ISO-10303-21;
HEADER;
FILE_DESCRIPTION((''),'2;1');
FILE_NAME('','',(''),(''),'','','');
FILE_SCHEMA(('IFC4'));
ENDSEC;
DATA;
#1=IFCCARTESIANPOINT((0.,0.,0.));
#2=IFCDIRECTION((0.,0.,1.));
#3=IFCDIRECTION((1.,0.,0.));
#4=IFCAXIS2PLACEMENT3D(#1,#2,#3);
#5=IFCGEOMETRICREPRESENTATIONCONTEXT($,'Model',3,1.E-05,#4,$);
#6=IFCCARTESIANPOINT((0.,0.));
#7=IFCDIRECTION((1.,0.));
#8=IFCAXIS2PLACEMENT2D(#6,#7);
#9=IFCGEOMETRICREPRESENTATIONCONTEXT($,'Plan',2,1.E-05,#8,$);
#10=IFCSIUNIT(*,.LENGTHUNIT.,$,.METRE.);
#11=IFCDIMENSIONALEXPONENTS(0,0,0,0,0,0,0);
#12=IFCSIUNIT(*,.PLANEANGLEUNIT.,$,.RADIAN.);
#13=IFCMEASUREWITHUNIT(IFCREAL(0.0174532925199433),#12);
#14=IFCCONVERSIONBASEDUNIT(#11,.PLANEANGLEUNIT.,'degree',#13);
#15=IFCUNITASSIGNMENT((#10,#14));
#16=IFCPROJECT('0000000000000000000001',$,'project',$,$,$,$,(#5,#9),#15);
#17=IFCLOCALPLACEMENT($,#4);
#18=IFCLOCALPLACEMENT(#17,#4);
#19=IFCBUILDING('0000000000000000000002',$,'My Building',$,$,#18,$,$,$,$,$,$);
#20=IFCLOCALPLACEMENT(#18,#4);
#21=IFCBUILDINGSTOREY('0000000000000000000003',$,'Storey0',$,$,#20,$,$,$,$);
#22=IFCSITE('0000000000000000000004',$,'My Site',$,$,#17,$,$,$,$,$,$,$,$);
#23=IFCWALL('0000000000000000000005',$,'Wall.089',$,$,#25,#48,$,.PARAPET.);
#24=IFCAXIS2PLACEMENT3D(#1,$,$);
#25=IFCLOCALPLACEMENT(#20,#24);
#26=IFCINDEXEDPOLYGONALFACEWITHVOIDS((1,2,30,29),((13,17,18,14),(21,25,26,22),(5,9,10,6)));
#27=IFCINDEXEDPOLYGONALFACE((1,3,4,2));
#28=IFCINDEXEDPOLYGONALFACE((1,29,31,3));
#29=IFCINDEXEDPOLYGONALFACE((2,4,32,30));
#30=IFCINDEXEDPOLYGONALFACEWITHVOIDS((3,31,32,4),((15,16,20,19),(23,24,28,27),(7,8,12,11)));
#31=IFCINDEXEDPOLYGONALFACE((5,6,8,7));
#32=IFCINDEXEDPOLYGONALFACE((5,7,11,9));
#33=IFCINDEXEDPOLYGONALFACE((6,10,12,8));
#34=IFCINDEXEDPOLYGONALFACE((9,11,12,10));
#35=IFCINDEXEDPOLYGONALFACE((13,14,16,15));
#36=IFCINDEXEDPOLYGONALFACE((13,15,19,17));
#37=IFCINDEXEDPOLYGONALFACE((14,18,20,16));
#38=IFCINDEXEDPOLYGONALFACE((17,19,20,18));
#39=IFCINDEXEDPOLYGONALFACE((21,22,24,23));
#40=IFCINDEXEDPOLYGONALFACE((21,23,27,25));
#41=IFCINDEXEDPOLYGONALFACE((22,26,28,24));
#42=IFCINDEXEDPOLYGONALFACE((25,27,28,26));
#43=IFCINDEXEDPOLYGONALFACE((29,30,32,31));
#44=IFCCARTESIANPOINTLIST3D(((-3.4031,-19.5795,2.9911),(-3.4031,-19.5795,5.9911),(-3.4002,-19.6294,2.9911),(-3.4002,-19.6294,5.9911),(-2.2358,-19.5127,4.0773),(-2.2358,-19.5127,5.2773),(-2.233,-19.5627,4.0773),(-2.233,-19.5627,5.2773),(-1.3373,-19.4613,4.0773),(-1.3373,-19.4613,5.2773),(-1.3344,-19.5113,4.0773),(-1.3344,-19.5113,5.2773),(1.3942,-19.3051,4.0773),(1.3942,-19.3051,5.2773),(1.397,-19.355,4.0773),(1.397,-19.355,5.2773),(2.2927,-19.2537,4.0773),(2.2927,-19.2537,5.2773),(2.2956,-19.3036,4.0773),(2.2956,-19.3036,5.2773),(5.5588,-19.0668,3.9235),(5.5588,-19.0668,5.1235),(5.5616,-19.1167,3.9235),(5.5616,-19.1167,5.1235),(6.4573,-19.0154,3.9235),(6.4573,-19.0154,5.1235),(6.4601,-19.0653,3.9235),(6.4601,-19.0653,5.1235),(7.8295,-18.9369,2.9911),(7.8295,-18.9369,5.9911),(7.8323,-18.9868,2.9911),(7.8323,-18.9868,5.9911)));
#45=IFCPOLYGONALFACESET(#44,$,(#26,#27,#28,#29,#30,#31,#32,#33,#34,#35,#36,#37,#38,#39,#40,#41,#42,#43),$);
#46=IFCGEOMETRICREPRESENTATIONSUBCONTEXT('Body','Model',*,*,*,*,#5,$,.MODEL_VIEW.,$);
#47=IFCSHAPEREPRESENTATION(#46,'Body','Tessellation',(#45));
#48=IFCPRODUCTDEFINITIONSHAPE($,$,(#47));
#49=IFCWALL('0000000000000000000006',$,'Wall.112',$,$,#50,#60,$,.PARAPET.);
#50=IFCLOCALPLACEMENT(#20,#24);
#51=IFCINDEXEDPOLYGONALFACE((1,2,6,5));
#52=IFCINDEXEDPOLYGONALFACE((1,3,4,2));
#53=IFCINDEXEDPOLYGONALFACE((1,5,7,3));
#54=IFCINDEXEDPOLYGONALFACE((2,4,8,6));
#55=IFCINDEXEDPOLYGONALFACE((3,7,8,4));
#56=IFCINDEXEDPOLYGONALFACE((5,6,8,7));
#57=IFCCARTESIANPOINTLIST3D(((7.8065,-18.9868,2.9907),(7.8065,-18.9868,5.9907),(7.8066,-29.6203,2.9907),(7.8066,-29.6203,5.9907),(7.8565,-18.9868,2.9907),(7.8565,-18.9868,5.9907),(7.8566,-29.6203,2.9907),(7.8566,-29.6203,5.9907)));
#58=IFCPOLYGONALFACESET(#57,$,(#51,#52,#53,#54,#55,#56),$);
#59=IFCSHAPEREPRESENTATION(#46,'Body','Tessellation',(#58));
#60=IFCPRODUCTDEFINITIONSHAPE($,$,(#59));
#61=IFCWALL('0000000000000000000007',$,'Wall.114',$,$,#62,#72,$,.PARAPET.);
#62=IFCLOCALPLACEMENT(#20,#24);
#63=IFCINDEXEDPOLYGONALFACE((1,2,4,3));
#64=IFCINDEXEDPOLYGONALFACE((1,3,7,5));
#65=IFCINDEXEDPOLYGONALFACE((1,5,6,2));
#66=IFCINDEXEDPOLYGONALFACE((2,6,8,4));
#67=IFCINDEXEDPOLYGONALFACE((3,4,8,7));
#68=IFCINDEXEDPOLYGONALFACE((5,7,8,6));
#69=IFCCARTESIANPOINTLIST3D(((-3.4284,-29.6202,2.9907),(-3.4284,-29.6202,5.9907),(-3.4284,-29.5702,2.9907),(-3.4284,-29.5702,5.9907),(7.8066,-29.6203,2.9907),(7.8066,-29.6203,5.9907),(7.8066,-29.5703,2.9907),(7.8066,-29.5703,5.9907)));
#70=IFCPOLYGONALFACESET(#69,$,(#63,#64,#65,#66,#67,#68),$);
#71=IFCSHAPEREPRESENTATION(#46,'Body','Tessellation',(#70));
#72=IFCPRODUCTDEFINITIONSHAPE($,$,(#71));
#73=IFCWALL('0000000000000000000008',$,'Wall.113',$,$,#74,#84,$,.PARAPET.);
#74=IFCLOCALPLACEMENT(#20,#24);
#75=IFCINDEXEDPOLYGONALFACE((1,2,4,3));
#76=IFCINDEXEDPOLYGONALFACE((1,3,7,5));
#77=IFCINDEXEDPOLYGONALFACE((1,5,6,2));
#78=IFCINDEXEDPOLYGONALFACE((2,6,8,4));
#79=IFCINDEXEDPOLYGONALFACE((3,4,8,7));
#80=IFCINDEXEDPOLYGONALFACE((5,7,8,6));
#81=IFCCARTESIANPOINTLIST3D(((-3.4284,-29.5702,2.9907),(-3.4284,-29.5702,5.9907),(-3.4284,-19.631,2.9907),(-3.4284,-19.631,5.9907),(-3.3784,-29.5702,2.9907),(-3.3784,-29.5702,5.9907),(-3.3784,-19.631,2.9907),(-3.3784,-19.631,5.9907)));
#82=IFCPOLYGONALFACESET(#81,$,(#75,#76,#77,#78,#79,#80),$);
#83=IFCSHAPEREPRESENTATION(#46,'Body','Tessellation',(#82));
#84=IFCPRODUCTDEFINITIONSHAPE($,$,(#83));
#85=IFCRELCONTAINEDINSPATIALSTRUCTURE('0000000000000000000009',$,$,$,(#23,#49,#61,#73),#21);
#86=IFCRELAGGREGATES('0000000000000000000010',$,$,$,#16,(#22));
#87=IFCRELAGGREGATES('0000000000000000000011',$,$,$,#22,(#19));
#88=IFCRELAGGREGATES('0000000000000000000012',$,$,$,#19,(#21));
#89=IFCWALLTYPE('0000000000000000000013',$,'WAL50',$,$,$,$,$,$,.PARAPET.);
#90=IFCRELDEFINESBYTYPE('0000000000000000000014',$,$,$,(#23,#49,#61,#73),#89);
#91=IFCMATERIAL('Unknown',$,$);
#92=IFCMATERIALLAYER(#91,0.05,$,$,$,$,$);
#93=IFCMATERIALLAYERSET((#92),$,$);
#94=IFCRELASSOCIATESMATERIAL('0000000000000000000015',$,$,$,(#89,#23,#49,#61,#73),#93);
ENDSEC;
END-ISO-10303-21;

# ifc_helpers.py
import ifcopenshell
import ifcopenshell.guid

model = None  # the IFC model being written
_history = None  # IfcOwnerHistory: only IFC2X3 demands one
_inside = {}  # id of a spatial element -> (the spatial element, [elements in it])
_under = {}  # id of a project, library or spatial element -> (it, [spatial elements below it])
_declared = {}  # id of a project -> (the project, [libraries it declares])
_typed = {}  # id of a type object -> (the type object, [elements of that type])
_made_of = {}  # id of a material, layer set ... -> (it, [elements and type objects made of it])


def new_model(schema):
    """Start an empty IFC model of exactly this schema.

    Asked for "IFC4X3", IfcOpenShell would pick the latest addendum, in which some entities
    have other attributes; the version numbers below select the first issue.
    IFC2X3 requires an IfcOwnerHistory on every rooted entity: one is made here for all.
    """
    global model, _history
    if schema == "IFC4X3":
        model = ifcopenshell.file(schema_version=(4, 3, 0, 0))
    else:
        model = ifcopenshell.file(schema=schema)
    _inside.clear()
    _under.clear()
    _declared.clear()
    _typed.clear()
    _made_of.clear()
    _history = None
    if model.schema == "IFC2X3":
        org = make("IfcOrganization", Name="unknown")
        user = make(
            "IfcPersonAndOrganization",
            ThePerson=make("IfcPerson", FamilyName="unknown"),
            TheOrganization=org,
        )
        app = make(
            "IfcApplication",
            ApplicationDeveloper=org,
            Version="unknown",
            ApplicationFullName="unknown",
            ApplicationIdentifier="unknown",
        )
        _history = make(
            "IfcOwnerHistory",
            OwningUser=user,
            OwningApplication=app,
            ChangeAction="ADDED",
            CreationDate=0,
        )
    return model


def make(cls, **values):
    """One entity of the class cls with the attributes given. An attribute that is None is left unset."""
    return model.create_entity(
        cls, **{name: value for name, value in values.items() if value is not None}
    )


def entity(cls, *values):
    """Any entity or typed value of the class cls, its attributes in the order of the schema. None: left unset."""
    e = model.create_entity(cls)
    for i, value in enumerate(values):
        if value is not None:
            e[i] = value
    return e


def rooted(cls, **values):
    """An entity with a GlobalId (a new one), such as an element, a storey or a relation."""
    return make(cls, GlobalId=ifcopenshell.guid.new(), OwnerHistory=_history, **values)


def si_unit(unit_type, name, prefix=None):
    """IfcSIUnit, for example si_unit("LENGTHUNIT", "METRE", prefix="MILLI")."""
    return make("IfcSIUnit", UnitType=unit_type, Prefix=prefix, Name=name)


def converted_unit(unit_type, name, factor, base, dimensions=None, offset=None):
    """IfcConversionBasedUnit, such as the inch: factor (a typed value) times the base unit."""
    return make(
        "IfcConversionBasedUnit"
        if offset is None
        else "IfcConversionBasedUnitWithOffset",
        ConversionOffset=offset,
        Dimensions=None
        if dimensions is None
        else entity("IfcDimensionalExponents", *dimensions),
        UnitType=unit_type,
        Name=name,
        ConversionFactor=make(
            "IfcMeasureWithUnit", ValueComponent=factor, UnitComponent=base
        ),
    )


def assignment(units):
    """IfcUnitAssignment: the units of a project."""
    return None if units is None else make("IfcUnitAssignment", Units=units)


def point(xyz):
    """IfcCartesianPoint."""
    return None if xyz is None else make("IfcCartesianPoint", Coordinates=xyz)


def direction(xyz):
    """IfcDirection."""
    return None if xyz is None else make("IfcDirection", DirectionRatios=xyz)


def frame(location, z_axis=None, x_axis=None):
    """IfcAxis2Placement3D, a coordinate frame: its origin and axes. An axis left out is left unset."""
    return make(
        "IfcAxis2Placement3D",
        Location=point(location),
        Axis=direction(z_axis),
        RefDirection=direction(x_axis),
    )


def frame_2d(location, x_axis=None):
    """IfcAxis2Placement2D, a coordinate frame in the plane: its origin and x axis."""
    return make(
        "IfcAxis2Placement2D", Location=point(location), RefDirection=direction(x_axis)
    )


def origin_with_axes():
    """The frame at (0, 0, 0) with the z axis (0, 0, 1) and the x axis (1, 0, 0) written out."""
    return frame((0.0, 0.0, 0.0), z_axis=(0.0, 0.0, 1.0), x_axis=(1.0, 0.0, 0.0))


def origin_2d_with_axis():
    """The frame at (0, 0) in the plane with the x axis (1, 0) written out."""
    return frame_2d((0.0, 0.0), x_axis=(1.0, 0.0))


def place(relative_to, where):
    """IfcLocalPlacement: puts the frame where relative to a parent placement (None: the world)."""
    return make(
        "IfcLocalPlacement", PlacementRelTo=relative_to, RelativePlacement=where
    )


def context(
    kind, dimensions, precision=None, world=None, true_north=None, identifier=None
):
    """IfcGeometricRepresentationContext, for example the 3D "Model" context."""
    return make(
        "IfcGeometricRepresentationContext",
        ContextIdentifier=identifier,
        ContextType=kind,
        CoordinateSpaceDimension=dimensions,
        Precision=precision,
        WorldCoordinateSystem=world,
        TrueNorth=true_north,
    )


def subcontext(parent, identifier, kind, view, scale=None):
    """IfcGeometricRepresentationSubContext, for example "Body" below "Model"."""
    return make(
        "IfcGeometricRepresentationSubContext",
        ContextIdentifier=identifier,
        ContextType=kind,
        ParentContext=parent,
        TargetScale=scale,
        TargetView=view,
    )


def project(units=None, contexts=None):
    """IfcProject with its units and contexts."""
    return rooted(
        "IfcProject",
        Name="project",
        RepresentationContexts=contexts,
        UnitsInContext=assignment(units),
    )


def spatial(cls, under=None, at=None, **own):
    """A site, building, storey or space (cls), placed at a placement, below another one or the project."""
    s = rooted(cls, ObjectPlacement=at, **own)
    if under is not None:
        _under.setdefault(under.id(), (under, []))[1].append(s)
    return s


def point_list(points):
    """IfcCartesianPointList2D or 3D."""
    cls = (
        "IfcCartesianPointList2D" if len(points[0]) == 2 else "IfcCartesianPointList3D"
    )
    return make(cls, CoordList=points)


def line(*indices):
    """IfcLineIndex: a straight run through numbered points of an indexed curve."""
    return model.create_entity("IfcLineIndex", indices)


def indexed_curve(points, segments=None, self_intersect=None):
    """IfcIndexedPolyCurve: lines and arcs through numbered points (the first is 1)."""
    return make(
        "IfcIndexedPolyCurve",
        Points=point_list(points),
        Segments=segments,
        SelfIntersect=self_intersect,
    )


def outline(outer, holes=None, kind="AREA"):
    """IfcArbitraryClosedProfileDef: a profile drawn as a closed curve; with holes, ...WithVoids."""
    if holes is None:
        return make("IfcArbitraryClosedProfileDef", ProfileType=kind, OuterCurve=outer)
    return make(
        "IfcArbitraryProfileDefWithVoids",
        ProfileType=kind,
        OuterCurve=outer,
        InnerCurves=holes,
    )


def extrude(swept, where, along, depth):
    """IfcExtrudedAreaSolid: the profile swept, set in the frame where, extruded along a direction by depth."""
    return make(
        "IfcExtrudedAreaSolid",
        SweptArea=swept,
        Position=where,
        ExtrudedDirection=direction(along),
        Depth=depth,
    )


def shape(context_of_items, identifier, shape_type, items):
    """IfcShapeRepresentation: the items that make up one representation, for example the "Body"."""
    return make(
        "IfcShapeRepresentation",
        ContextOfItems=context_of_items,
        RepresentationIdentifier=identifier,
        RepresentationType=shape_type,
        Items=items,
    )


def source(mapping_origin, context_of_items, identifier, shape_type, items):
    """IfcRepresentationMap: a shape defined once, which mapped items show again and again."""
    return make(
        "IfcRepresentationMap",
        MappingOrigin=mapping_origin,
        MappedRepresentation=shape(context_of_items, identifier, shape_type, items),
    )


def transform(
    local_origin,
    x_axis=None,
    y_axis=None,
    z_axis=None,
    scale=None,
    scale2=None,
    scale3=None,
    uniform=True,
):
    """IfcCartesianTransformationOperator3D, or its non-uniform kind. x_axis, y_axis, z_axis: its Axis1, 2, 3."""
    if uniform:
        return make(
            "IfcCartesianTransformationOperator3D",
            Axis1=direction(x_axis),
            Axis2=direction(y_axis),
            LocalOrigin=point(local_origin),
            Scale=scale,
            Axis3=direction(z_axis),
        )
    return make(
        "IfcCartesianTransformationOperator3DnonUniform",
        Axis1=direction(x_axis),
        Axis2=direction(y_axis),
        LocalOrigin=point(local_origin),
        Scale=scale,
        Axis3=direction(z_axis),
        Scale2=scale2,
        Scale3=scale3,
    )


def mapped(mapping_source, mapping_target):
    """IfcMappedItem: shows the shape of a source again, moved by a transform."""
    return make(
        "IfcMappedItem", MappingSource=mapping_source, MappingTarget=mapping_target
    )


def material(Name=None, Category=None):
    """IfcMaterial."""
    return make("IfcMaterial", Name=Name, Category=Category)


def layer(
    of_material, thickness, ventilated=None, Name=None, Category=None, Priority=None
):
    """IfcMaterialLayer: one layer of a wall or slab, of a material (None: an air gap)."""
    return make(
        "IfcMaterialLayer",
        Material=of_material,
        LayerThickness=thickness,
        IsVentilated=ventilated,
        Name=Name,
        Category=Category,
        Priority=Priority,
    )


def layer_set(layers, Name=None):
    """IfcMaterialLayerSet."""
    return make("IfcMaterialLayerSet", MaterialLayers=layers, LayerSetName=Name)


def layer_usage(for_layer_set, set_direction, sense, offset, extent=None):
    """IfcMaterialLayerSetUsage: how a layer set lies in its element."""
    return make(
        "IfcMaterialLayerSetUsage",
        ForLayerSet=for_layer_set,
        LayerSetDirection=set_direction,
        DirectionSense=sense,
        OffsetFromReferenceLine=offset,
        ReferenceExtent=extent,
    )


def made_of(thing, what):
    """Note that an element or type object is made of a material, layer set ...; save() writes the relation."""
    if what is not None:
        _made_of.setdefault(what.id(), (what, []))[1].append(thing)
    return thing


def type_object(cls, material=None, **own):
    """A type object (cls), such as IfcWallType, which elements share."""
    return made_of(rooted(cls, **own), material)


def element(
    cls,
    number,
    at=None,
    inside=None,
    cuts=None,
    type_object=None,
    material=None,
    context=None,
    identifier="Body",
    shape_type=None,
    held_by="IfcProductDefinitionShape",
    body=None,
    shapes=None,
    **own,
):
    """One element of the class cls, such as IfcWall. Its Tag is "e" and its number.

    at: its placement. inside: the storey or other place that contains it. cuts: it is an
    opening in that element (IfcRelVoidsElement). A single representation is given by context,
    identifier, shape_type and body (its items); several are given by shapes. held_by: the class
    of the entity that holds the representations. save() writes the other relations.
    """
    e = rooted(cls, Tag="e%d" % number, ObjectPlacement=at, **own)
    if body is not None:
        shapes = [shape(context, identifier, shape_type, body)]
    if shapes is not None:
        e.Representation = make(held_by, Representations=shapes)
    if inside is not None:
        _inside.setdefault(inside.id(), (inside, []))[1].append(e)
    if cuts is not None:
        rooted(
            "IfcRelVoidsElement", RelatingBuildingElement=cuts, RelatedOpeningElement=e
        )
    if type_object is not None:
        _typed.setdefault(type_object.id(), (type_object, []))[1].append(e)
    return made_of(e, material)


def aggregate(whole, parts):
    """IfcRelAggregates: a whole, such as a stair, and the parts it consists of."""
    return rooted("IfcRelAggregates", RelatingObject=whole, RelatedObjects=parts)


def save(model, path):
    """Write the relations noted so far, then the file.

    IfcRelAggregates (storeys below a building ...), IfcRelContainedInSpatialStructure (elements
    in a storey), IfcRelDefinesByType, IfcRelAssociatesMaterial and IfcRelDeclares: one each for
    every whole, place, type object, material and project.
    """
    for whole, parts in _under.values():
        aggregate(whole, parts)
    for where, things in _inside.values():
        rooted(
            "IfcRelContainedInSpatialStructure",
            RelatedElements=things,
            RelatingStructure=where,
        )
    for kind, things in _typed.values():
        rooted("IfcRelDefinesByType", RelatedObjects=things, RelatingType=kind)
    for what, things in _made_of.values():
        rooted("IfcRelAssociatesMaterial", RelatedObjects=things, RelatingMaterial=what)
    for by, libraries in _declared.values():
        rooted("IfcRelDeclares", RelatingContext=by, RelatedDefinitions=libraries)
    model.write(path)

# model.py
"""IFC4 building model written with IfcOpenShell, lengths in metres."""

from ifc_helpers import new_model, entity, si_unit, converted_unit, frame, origin_with_axes, origin_2d_with_axis, place, context, subcontext, project, spatial, line, indexed_curve, outline, extrude, source, transform, mapped, material, layer, layer_set, layer_usage, type_object, element, save


model = new_model("IFC4")

# Units and contexts
model_context = context("Model", 3, precision=1e-05, world=origin_with_axes())
plan_context = context("Plan", 2, precision=1e-05, world=origin_2d_with_axis())
body_context = subcontext(model_context, "Body", "Model", "MODEL_VIEW")
ifc_project = project(units=[si_unit("LENGTHUNIT", "METRE"), converted_unit("PLANEANGLEUNIT", "degree", entity("IfcReal", 0.0174532925199433), si_unit("PLANEANGLEUNIT", "RADIAN"), dimensions=[0, 0, 0, 0, 0, 0, 0])], contexts=[model_context, plan_context])

# Site, building, storey
site_placement = place(None, origin_with_axes())
site = spatial("IfcSite", under=ifc_project, at=site_placement, Name="My Site")
building_placement = place(site_placement, origin_with_axes())
building = spatial("IfcBuilding", under=site, at=building_placement, Name="My Building")
storey_placement = place(building_placement, origin_with_axes())
storey = spatial("IfcBuildingStorey", under=building, at=storey_placement, Name="Storey0")

# Wall, openings
ifc_material = material(Name="Unknown")
ifc_layer = layer(ifc_material, 0.05)
ifc_layer_set = layer_set([ifc_layer])
ifc_layer_usage_1 = layer_usage(ifc_layer_set, "AXIS2", "POSITIVE", 0.0)
wall_type = type_object("IfcWallType", Name="WAL50", PredefinedType="PARAPET", material=ifc_layer_set)
wall_1_placement = place(storey_placement, frame((7.8295, -18.9369, 2.9911), z_axis=(0.0, 0.0, 1.0), x_axis=(-0.998368, -0.057116, 0.0)))
wall_1 = element("IfcWall", 1, at=wall_1_placement, inside=storey, type_object=wall_type, material=ifc_layer_usage_1, Name="Wall.089", PredefinedType="PARAPET", context=body_context, shape_type="SweptSolid", body=[
    extrude(outline(indexed_curve([(0.0, 0.0), (0.0, 0.05), (11.2509, 0.05), (11.2509, 0.0), (0.0, 0.0)], self_intersect=False)), origin_with_axes(), (0.0, 0.0, 1.0), 3.0),
])
shared_shape = source(origin_with_axes(), body_context, "Body", "SolidModel", [
    extrude(outline(indexed_curve([(0.0, 0.0), (0.9, 0.0), (0.9, 1.2), (0.0, 1.2)], segments=[line(1, 2, 3, 4, 1)])), frame((0.0, -0.6, 0.0), z_axis=(0.0, -1.0, 0.0), x_axis=(1.0, 0.0, 0.0)), (0.0, 0.0, -1.0), 1.2),
])
opening_1_placement = place(wall_1_placement, frame((9.1817, 0.0, 1.0862), z_axis=(0.0, 0.0, 1.0), x_axis=(1.0, 0.0, 0.0)))
element("IfcOpeningElement", 2, at=opening_1_placement, cuts=wall_1, PredefinedType="OPENING", context=body_context, shape_type="MappedRepresentation", body=[
    mapped(shared_shape, transform((0.0, 0.0, 0.0), x_axis=(1.0, 0.0, 0.0), y_axis=(0.0, 1.0, 0.0), z_axis=(0.0, 0.0, 1.0), scale=1.0)),
])
opening_2_placement = place(wall_1_placement, frame((5.5458, 0.0, 1.0862), z_axis=(0.0, 0.0, 1.0), x_axis=(1.0, 0.0, 0.0)))
element("IfcOpeningElement", 3, at=opening_2_placement, cuts=wall_1, PredefinedType="OPENING", context=body_context, shape_type="MappedRepresentation", body=[
    mapped(shared_shape, transform((0.0, 0.0, 0.0), x_axis=(1.0, 0.0, 0.0), y_axis=(0.0, 1.0, 0.0), z_axis=(0.0, 0.0, 1.0), scale=1.0)),
])
opening_3_placement = place(wall_1_placement, frame((1.3744, 0.0, 0.9323), z_axis=(0.0, 0.0, 1.0), x_axis=(1.0, 0.0, 0.0)))
element("IfcOpeningElement", 4, at=opening_3_placement, cuts=wall_1, PredefinedType="OPENING", context=body_context, shape_type="MappedRepresentation", body=[
    mapped(shared_shape, transform((0.0, 0.0, 0.0), x_axis=(1.0, 0.0, 0.0), y_axis=(0.0, 1.0, 0.0), z_axis=(0.0, 0.0, 1.0), scale=1.0)),
])

# Walls
ifc_layer_usage_2 = layer_usage(ifc_layer_set, "AXIS2", "POSITIVE", 0.0)
wall_2_placement = place(storey_placement, frame((7.8065, -18.9868, 2.9907), z_axis=(0.0, 0.0, 1.0), x_axis=(0.000007, -1.0, 0.0)))
element("IfcWall", 5, at=wall_2_placement, inside=storey, type_object=wall_type, material=ifc_layer_usage_2, Name="Wall.112", PredefinedType="PARAPET", context=body_context, shape_type="SweptSolid", body=[
    extrude(outline(indexed_curve([(0.0, 0.0), (0.0, 0.05), (10.6334, 0.05), (10.6334, 0.0), (0.0, 0.0)], self_intersect=False)), origin_with_axes(), (0.0, 0.0, 1.0), 3.0),
])
ifc_layer_usage_3 = layer_usage(ifc_layer_set, "AXIS2", "POSITIVE", 0.0)
wall_3_placement = place(storey_placement, frame((7.8066, -29.5703, 2.9907), z_axis=(0.0, 0.0, 1.0), x_axis=(-1.0, 0.000002, 0.0)))
element("IfcWall", 6, at=wall_3_placement, inside=storey, type_object=wall_type, material=ifc_layer_usage_3, Name="Wall.114", PredefinedType="PARAPET", context=body_context, shape_type="SweptSolid", body=[
    extrude(outline(indexed_curve([(0.0, 0.0), (0.0, 0.05), (11.235, 0.05), (11.235, 0.0), (0.0, 0.0)], self_intersect=False)), origin_with_axes(), (0.0, 0.0, 1.0), 3.0),
])
ifc_layer_usage_4 = layer_usage(ifc_layer_set, "AXIS2", "POSITIVE", 0.0)
wall_4_placement = place(storey_placement, frame((-3.3784, -29.5702, 2.9907), z_axis=(0.0, 0.0, 1.0), x_axis=(0.0, 1.0, 0.0)))
element("IfcWall", 7, at=wall_4_placement, inside=storey, type_object=wall_type, material=ifc_layer_usage_4, Name="Wall.113", PredefinedType="PARAPET", context=body_context, shape_type="SweptSolid", body=[
    extrude(outline(indexed_curve([(0.0, 0.0), (0.0, 0.05), (9.9392, 0.05), (9.9392, 0.0), (0.0, 0.0)], self_intersect=False)), origin_with_axes(), (0.0, 0.0, 1.0), 3.0),
])

save(model, "model.ifc")
